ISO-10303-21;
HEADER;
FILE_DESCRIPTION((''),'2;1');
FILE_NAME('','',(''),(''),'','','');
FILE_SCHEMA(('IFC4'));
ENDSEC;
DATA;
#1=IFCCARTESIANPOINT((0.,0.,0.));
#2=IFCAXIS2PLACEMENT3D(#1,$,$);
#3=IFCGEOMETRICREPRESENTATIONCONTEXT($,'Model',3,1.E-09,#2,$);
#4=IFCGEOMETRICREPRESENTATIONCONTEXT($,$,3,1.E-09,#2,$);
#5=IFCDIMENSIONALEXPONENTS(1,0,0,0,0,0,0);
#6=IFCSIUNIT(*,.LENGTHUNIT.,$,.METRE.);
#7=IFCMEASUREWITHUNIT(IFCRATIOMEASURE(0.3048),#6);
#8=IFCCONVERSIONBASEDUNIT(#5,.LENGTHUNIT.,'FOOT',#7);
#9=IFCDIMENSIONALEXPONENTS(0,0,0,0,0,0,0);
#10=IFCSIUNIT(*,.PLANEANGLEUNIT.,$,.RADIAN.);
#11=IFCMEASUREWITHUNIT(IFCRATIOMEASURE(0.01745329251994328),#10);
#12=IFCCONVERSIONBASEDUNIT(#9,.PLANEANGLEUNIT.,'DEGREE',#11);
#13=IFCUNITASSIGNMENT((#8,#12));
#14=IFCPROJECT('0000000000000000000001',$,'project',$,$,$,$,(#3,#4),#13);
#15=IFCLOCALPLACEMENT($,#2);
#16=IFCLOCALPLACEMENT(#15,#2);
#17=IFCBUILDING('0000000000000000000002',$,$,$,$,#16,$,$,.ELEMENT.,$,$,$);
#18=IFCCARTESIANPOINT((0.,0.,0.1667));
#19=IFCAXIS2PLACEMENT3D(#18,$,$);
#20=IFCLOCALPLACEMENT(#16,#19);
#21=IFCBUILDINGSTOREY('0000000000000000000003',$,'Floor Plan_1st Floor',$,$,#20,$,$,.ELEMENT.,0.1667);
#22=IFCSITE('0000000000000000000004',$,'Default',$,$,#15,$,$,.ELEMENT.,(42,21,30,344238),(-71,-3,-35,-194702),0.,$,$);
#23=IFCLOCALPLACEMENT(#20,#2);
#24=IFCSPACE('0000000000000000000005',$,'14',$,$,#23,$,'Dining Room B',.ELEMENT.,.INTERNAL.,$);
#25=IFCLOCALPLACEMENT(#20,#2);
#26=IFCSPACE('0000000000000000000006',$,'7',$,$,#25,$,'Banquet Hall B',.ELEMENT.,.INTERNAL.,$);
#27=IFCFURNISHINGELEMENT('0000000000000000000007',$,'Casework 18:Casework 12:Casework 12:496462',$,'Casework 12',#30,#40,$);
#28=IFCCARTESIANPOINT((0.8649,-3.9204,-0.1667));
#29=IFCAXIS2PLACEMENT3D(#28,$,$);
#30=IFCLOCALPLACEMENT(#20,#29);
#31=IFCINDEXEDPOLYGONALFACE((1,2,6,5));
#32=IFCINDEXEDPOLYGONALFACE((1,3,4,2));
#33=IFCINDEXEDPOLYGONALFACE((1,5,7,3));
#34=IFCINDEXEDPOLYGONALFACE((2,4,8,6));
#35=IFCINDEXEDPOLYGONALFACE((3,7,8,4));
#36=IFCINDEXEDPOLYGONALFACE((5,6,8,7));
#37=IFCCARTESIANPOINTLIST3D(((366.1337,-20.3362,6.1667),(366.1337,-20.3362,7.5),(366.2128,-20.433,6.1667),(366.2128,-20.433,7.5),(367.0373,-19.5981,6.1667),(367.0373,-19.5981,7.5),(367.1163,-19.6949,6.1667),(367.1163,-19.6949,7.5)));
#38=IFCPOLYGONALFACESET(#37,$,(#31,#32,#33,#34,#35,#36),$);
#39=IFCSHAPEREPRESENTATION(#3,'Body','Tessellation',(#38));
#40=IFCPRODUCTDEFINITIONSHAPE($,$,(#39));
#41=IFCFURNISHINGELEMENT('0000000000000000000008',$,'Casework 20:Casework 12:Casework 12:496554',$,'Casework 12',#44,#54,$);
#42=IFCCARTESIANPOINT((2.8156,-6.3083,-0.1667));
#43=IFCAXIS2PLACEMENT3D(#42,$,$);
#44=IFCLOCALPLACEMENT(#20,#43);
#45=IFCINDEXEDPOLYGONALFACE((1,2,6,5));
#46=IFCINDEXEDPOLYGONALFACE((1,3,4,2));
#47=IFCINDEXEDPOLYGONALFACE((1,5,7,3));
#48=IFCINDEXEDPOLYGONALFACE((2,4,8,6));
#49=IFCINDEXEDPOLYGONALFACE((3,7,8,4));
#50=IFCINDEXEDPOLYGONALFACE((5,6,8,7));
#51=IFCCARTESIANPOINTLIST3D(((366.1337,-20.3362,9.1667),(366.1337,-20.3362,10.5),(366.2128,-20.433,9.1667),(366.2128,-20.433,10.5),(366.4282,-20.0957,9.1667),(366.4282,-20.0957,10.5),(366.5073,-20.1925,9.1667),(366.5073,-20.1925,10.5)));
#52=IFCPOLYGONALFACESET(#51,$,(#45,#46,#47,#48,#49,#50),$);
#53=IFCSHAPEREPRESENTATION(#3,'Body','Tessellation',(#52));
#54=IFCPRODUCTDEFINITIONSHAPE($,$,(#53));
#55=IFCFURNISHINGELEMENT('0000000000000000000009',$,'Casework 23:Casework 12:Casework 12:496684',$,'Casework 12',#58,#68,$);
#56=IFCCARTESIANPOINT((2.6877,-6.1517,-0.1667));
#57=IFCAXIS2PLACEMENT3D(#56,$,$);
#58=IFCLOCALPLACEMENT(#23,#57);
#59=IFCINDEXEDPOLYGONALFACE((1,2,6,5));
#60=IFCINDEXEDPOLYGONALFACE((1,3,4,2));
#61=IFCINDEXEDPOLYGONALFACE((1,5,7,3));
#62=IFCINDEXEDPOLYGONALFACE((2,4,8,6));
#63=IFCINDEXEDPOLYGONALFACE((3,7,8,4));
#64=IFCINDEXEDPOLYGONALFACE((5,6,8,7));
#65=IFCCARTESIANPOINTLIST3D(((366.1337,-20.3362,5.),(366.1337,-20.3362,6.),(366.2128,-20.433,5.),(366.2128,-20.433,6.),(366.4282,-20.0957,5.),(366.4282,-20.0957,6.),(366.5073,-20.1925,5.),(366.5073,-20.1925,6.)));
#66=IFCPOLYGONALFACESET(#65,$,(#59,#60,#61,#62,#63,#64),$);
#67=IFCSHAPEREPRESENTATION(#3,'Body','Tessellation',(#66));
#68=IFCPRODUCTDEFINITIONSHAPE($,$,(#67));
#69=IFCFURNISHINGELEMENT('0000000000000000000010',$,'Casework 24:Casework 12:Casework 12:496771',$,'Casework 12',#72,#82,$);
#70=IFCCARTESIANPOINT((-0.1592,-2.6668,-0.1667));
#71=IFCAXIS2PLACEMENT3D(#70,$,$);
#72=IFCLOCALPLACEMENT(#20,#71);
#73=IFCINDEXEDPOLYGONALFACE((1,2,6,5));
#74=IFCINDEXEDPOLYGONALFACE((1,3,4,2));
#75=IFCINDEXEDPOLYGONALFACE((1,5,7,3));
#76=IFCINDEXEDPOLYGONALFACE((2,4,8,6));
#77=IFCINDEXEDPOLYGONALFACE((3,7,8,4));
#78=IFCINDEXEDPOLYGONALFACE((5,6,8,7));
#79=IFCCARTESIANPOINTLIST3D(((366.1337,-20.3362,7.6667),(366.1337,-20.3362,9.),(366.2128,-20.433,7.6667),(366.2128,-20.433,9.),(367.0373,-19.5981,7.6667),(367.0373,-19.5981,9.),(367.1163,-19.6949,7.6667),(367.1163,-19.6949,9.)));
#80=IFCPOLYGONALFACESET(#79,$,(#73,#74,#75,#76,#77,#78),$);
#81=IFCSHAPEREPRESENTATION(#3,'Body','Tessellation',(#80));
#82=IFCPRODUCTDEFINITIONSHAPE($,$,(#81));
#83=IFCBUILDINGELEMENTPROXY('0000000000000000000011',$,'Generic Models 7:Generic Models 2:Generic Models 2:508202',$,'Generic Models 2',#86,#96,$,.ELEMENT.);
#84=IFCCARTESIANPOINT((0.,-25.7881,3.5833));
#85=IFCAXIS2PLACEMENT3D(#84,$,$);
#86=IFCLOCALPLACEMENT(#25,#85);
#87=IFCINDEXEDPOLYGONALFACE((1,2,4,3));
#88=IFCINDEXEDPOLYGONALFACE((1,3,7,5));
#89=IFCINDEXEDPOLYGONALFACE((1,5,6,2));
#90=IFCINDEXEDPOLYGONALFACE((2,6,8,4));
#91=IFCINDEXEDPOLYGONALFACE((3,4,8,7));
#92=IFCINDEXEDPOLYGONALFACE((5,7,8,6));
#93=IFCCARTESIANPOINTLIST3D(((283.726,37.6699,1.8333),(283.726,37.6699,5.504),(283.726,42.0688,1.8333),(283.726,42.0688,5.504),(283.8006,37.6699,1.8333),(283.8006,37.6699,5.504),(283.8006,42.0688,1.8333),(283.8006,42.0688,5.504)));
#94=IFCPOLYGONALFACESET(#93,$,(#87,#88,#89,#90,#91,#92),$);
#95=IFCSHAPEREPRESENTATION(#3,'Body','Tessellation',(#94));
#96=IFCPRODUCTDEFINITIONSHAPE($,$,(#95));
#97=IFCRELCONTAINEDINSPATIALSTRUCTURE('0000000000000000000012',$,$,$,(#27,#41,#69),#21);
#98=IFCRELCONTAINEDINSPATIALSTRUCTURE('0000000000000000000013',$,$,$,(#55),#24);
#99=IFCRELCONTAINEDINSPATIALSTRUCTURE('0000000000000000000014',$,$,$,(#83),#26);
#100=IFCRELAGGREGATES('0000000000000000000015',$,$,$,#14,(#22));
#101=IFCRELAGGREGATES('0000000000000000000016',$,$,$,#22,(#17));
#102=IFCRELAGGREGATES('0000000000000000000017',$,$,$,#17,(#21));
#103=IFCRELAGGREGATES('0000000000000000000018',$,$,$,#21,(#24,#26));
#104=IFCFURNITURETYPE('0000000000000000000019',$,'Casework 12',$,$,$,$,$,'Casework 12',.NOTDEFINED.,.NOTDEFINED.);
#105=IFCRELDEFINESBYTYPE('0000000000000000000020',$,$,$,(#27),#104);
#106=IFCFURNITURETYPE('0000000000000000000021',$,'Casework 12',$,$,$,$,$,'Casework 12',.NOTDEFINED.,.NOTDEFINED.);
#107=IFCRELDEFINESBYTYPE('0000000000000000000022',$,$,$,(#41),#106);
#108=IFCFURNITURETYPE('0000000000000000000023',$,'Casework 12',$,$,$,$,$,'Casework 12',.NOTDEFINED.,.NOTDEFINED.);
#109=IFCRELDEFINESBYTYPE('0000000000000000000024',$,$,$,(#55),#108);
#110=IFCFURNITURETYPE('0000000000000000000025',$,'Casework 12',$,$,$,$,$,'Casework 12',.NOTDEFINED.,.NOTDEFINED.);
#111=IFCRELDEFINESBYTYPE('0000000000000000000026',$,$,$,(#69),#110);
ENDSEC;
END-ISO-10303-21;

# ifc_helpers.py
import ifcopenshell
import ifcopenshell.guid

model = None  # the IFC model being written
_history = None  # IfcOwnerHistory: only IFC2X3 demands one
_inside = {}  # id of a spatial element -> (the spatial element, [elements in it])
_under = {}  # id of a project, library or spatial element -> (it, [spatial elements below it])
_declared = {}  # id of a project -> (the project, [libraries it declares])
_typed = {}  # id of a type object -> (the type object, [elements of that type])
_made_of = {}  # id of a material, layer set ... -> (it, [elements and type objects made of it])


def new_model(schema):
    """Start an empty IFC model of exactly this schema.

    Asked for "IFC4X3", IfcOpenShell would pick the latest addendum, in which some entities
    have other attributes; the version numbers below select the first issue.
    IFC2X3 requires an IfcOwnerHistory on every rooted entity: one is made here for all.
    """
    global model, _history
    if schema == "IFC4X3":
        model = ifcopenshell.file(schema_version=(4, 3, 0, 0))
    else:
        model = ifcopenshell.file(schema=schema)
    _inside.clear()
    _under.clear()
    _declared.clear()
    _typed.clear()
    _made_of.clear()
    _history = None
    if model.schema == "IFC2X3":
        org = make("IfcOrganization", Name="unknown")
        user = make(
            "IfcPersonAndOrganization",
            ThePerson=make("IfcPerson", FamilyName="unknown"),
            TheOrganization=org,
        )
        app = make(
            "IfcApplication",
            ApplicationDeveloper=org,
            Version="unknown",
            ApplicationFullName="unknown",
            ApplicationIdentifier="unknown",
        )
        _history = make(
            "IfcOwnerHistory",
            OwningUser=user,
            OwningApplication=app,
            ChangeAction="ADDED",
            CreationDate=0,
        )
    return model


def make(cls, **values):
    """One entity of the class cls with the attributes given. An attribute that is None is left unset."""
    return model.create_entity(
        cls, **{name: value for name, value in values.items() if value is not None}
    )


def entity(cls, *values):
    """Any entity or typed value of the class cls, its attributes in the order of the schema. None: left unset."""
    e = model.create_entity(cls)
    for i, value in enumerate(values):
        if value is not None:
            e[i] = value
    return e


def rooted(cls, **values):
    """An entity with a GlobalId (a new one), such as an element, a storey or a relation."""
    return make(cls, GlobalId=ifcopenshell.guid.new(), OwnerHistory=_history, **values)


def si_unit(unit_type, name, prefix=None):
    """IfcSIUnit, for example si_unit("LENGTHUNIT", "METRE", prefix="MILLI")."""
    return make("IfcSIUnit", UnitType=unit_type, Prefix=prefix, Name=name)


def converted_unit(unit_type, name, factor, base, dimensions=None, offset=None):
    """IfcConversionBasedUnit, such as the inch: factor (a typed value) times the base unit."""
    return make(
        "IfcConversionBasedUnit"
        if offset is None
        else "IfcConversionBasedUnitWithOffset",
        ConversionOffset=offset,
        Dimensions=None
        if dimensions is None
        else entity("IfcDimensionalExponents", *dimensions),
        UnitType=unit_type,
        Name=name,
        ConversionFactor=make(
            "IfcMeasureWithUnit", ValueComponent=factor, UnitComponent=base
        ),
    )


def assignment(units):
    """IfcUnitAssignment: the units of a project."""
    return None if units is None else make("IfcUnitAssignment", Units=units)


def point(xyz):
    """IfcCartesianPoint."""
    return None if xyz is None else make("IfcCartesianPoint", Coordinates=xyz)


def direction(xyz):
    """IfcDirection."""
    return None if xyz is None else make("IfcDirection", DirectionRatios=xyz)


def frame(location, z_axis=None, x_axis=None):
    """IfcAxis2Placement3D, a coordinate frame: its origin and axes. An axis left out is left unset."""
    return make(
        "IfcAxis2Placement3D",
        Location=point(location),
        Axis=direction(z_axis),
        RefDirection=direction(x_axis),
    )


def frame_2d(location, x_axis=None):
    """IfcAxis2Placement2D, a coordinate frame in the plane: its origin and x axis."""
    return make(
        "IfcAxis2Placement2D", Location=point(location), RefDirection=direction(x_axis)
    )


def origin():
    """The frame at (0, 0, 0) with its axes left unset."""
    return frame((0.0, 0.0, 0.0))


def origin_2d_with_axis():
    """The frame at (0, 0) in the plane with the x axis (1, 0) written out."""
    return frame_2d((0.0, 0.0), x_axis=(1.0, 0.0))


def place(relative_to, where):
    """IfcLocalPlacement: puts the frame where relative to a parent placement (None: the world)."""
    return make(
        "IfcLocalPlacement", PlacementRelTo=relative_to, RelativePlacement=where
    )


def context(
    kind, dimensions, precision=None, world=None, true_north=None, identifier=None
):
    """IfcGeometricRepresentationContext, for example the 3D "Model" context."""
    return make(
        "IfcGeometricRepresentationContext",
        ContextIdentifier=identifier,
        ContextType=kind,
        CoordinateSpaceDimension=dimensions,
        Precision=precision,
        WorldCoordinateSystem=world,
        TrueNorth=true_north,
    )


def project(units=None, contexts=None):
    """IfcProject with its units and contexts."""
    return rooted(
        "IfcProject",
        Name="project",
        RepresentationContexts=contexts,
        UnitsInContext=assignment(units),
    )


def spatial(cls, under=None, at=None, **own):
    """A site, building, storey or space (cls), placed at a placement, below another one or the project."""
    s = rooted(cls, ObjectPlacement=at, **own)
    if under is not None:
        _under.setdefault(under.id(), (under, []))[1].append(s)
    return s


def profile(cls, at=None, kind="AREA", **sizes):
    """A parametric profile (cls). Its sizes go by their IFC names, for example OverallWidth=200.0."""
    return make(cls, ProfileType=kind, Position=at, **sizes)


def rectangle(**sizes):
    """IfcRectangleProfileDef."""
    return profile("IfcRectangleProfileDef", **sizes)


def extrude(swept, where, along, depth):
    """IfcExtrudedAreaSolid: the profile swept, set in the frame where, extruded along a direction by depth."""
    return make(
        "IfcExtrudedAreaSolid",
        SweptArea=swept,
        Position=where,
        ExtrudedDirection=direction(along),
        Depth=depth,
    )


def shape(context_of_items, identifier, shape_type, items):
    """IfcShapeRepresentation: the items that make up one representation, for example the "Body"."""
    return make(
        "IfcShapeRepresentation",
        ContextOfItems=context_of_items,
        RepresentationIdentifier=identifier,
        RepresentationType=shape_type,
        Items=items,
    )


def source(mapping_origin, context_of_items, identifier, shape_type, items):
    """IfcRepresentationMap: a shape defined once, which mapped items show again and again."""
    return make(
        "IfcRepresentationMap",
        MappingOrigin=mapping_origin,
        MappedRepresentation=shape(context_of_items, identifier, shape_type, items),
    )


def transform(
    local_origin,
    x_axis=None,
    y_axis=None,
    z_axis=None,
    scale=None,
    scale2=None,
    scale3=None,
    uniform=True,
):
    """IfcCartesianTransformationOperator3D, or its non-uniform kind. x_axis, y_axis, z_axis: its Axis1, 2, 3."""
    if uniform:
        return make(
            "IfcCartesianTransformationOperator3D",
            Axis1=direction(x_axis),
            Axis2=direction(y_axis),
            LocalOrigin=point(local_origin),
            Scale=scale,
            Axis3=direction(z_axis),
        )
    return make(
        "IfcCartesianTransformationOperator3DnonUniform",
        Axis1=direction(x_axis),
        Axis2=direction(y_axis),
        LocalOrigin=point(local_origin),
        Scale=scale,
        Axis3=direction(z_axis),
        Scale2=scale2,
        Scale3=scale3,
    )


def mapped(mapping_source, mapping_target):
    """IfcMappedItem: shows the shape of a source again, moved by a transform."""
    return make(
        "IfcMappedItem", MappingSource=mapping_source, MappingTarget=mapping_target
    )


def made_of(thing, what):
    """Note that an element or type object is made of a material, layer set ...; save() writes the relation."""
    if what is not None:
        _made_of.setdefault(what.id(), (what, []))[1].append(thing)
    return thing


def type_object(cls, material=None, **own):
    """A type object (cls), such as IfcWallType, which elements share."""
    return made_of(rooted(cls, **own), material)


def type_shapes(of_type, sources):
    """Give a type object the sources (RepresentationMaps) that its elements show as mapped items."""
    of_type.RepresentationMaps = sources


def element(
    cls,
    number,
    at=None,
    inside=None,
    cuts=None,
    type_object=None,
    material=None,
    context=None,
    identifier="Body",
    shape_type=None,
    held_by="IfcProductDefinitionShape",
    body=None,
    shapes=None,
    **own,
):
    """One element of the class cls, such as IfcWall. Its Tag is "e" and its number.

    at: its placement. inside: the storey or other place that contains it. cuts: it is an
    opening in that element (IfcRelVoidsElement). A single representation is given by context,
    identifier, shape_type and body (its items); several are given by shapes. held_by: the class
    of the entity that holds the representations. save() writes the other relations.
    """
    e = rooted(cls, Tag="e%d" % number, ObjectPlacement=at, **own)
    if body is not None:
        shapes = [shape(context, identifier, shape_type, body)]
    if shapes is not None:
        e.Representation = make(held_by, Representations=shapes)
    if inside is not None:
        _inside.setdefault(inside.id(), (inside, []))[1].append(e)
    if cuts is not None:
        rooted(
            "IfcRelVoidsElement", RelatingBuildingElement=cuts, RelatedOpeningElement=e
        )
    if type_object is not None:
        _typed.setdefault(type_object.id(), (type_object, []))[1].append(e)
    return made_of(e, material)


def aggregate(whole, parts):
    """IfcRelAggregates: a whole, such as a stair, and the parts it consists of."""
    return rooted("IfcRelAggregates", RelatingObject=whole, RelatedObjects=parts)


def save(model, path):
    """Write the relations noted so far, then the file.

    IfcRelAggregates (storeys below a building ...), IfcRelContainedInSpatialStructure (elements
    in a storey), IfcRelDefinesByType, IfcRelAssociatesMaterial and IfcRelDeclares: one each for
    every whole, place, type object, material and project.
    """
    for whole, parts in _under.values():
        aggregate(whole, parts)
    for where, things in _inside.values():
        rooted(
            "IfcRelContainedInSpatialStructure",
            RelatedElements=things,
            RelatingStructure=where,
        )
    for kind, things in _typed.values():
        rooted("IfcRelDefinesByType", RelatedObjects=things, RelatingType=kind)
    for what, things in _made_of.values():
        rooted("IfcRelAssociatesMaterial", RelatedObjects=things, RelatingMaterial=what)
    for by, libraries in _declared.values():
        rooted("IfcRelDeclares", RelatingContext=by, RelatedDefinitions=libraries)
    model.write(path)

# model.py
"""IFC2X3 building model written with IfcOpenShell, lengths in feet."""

from ifc_helpers import new_model, entity, si_unit, converted_unit, frame, origin, origin_2d_with_axis, place, context, project, spatial, rectangle, extrude, source, transform, mapped, type_object, type_shapes, element, save


model = new_model("IFC2X3")

# Units and contexts
model_context = context("Model", 3, precision=1e-09, world=origin())
context_of_model = context(None, 3, precision=1e-09, world=origin())
ifc_project = project(units=[converted_unit("LENGTHUNIT", "FOOT", entity("IfcRatioMeasure", 0.3048), si_unit("LENGTHUNIT", "METRE"), dimensions=[1, 0, 0, 0, 0, 0, 0]), converted_unit("PLANEANGLEUNIT", "DEGREE", entity("IfcRatioMeasure", 0.01745329251994328), si_unit("PLANEANGLEUNIT", "RADIAN"), dimensions=[0, 0, 0, 0, 0, 0, 0])], contexts=[model_context, context_of_model])

# Site, building, storey
site_placement = place(None, origin())
site = spatial("IfcSite", under=ifc_project, at=site_placement, Name="Default", CompositionType="ELEMENT", RefLatitude=(42, 21, 30, 344238), RefLongitude=(-71, -3, -35, -194702), RefElevation=0.0)
building_placement = place(site_placement, origin())
building = spatial("IfcBuilding", under=site, at=building_placement, CompositionType="ELEMENT")
storey_placement = place(building_placement, frame((0.0, 0.0, 0.1667)))
storey = spatial("IfcBuildingStorey", under=building, at=storey_placement, Name="Floor Plan_1st Floor", CompositionType="ELEMENT", Elevation=0.1667)

# Furnishing elements
furniture_type_1 = type_object("IfcFurnitureType", Name="Casework 12", ElementType="Casework 12", AssemblyPlace="NOTDEFINED")
shared_shape_1 = source(origin(), model_context, "Body", "SweptSolid", [
    extrude(rectangle(XDim=0.125, YDim=1.1667, at=origin_2d_with_axis()), frame((366.625, -20.0156, 6.1667), z_axis=(0.0, 0.0, 1.0), x_axis=(-0.632643, 0.774444, 0.0)), (0.0, 0.0, 1.0), 1.3333),
])
type_shapes(furniture_type_1, [shared_shape_1])
furnishing_1_placement = place(storey_placement, frame((0.8649, -3.9204, -0.1667)))
element("IfcFurnishingElement", 1, at=furnishing_1_placement, inside=storey, type_object=furniture_type_1, Name="Casework 18:Casework 12:Casework 12:496462", ObjectType="Casework 12", context=model_context, shape_type="MappedRepresentation", body=[
    mapped(shared_shape_1, transform((0.0, 0.0, 0.0), scale=1.0)),
])
furniture_type_2 = type_object("IfcFurnitureType", Name="Casework 12", ElementType="Casework 12", AssemblyPlace="NOTDEFINED")
shared_shape_2 = source(origin(), model_context, "Body", "SweptSolid", [
    extrude(rectangle(XDim=0.125, YDim=0.3802, at=origin_2d_with_axis()), frame((366.3205, -20.2644, 9.1667), z_axis=(0.0, 0.0, 1.0), x_axis=(-0.632643, 0.774444, 0.0)), (0.0, 0.0, 1.0), 1.3333),
])
type_shapes(furniture_type_2, [shared_shape_2])
furnishing_2_placement = place(storey_placement, frame((2.8156, -6.3083, -0.1667)))
element("IfcFurnishingElement", 2, at=furnishing_2_placement, inside=storey, type_object=furniture_type_2, Name="Casework 20:Casework 12:Casework 12:496554", ObjectType="Casework 12", context=model_context, shape_type="MappedRepresentation", body=[
    mapped(shared_shape_2, transform((0.0, 0.0, 0.0), scale=1.0)),
])

# Shared definitions
space_1_placement = place(storey_placement, origin())
space_1 = spatial("IfcSpace", under=storey, at=space_1_placement, Name="14", LongName="Dining Room B", CompositionType="ELEMENT", InteriorOrExteriorSpace="INTERNAL")

# Furnishing elements
furniture_type_3 = type_object("IfcFurnitureType", Name="Casework 12", ElementType="Casework 12", AssemblyPlace="NOTDEFINED")
shared_shape_3 = source(origin(), model_context, "Body", "SweptSolid", [
    extrude(rectangle(XDim=0.125, YDim=0.3802, at=origin_2d_with_axis()), frame((366.3205, -20.2644, 5.0), z_axis=(0.0, 0.0, 1.0), x_axis=(-0.632643, 0.774444, 0.0)), (0.0, 0.0, 1.0), 1.0),
])
type_shapes(furniture_type_3, [shared_shape_3])
furnishing_3_placement = place(space_1_placement, frame((2.6877, -6.1517, -0.1667)))
element("IfcFurnishingElement", 3, at=furnishing_3_placement, inside=space_1, type_object=furniture_type_3, Name="Casework 23:Casework 12:Casework 12:496684", ObjectType="Casework 12", context=model_context, shape_type="MappedRepresentation", body=[
    mapped(shared_shape_3, transform((0.0, 0.0, 0.0), scale=1.0)),
])
furniture_type_4 = type_object("IfcFurnitureType", Name="Casework 12", ElementType="Casework 12", AssemblyPlace="NOTDEFINED")
shared_shape_4 = source(origin(), model_context, "Body", "SweptSolid", [
    extrude(rectangle(XDim=0.125, YDim=1.1667, at=origin_2d_with_axis()), frame((366.625, -20.0156, 7.6667), z_axis=(0.0, 0.0, 1.0), x_axis=(-0.632643, 0.774444, 0.0)), (0.0, 0.0, 1.0), 1.3333),
])
type_shapes(furniture_type_4, [shared_shape_4])
furnishing_4_placement = place(storey_placement, frame((-0.1592, -2.6668, -0.1667)))
element("IfcFurnishingElement", 4, at=furnishing_4_placement, inside=storey, type_object=furniture_type_4, Name="Casework 24:Casework 12:Casework 12:496771", ObjectType="Casework 12", context=model_context, shape_type="MappedRepresentation", body=[
    mapped(shared_shape_4, transform((0.0, 0.0, 0.0), scale=1.0)),
])

# Shared definitions
space_2_placement = place(storey_placement, origin())
space_2 = spatial("IfcSpace", under=storey, at=space_2_placement, Name="7", LongName="Banquet Hall B", CompositionType="ELEMENT", InteriorOrExteriorSpace="INTERNAL")

# Building element proxy
shared_shape_5 = source(origin(), model_context, "Body", "SweptSolid", [
    extrude(rectangle(XDim=4.399, YDim=0.0746, at=origin_2d_with_axis()), frame((283.7633, 39.8693, 1.8333), z_axis=(0.0, 0.0, 1.0), x_axis=(0.0, 1.0, 0.0)), (0.0, 0.0, 1.0), 3.6707),
])
proxy_placement = place(space_2_placement, frame((0.0, -25.7881, 3.5833)))
element("IfcBuildingElementProxy", 5, at=proxy_placement, inside=space_2, Name="Generic Models 7:Generic Models 2:Generic Models 2:508202", ObjectType="Generic Models 2", CompositionType="ELEMENT", context=model_context, shape_type="MappedRepresentation", body=[
    mapped(shared_shape_5, transform((0.0, 0.0, 0.0), scale=1.0)),
])

save(model, "model.ifc")
